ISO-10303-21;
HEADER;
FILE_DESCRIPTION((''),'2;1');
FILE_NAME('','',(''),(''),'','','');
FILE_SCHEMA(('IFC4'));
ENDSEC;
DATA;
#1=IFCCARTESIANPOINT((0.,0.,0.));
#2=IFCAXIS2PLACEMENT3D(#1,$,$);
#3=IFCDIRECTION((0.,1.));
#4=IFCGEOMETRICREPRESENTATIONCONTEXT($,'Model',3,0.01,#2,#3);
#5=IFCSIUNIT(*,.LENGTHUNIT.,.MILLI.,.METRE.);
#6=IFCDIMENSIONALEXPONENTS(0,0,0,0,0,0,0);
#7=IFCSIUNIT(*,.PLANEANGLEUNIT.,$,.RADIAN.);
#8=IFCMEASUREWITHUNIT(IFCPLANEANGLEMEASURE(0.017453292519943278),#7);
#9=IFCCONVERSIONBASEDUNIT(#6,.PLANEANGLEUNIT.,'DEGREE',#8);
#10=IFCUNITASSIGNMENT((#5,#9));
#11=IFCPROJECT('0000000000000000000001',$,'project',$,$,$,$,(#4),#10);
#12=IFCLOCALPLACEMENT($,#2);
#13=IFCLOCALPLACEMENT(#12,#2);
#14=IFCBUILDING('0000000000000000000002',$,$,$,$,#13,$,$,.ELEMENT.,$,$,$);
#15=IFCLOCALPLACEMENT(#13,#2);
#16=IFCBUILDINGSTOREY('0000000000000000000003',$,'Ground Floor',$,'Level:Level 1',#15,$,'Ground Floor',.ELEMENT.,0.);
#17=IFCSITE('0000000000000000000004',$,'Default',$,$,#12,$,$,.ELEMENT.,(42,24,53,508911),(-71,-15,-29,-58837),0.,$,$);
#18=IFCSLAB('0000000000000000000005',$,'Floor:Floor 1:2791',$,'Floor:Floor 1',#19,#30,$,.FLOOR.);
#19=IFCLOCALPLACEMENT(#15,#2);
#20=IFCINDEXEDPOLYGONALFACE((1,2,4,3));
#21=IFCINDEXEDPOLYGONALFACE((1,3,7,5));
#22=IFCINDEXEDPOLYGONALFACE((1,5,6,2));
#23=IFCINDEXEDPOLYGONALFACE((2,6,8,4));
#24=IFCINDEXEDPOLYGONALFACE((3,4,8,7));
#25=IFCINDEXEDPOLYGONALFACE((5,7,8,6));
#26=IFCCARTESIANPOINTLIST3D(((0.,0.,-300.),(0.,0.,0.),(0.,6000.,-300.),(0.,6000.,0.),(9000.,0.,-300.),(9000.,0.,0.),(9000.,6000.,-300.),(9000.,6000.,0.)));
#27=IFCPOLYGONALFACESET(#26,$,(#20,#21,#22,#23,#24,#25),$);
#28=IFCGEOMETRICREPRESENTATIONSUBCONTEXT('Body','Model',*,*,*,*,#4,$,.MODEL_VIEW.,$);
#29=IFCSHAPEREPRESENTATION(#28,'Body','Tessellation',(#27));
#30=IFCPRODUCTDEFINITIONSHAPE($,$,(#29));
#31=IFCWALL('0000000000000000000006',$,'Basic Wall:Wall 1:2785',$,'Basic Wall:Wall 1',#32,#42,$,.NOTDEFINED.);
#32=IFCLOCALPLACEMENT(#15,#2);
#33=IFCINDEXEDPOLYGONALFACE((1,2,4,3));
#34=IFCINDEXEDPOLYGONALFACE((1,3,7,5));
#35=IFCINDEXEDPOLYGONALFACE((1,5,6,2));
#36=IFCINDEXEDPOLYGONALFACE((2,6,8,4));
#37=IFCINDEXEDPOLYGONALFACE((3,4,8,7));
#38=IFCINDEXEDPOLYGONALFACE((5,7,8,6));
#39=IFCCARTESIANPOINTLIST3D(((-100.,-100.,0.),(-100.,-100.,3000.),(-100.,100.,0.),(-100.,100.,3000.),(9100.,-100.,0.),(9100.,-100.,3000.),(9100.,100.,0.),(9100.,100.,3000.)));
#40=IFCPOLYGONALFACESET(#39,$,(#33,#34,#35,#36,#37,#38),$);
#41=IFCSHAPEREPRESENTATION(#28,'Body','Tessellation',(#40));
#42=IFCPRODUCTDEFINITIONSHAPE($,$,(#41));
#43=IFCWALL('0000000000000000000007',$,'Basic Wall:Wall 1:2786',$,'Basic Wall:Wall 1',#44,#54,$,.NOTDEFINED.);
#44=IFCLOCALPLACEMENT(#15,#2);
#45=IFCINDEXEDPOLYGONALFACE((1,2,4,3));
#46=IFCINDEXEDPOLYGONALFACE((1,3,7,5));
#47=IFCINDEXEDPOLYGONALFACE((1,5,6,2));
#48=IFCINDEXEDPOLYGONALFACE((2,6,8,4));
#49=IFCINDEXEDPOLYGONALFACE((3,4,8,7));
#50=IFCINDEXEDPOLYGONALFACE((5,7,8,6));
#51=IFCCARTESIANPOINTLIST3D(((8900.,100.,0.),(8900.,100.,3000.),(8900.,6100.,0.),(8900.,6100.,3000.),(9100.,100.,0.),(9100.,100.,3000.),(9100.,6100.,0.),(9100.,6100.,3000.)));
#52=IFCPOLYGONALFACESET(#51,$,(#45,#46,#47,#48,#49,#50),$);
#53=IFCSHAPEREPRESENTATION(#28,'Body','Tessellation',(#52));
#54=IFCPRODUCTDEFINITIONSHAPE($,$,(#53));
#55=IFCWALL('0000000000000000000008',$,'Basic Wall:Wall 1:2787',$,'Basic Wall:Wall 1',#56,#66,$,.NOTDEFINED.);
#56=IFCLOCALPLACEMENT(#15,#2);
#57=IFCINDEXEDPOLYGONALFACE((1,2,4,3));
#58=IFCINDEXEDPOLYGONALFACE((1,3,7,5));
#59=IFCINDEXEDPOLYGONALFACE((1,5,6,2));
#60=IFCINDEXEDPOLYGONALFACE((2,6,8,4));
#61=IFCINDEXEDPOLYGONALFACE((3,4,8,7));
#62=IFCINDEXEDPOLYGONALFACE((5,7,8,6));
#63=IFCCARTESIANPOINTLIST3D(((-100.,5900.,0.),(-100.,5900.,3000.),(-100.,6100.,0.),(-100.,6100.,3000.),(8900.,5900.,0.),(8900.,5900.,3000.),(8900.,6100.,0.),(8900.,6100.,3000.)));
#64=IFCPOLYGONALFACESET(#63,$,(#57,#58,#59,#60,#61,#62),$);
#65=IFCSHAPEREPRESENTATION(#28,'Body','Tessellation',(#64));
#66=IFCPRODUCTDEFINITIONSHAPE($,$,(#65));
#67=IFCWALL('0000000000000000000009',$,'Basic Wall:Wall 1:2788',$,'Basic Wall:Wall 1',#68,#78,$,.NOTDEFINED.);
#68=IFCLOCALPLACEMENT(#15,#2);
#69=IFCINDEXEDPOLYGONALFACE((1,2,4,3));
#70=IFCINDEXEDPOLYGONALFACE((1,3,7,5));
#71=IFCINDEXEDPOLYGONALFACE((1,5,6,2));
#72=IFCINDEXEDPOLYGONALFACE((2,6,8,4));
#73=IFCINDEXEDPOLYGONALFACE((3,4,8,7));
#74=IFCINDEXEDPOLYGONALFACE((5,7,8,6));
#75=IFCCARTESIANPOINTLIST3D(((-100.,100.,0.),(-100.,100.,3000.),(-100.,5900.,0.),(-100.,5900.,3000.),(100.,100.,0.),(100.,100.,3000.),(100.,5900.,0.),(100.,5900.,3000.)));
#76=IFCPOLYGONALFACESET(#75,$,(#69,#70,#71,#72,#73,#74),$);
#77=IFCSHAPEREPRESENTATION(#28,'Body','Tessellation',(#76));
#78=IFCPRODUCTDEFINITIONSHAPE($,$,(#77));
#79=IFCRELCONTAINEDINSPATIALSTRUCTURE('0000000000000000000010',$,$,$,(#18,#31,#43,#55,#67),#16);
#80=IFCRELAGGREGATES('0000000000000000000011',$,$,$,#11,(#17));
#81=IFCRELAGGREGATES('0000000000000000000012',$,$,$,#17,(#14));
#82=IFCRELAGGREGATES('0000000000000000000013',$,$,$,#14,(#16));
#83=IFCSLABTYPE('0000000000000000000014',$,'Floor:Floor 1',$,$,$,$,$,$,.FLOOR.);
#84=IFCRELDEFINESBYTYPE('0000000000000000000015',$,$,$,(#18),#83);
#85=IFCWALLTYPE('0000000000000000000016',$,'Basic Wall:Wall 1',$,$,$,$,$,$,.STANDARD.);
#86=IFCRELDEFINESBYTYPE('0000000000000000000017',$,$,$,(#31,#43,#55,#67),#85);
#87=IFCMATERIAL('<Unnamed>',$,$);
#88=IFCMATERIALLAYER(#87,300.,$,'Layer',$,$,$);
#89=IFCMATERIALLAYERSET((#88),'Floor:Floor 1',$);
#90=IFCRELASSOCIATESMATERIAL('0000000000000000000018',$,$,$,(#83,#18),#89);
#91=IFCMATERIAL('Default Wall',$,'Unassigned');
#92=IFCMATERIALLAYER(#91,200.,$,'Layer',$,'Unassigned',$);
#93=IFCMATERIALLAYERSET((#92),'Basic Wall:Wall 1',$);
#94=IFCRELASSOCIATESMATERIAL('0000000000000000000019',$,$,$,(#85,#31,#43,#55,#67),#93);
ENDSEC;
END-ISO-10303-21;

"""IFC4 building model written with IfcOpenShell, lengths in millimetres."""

from ifc_helpers import new_model, entity, si_unit, converted_unit, direction, frame, frame_2d, origin, origin_2d_with_axis, place, context, subcontext, project, spatial, rectangle, extrude, material, layer, layer_set, layer_usage, type_object, element, save


model = new_model("IFC4")

# Units and contexts
model_context = context("Model", 3, precision=0.01, world=origin(), true_north=direction((0.0, 1.0)))
body_context = subcontext(model_context, "Body", "Model", "MODEL_VIEW")
ifc_project = project(units=[si_unit("LENGTHUNIT", "METRE", prefix="MILLI"), converted_unit("PLANEANGLEUNIT", "DEGREE", entity("IfcPlaneAngleMeasure", 0.017453292519943278), si_unit("PLANEANGLEUNIT", "RADIAN"), dimensions=[0, 0, 0, 0, 0, 0, 0])], contexts=[model_context])

# Site, building, storey
site_placement = place(None, origin())
site = spatial("IfcSite", under=ifc_project, at=site_placement, Name="Default", CompositionType="ELEMENT", RefLatitude=(42, 24, 53, 508911), RefLongitude=(-71, -15, -29, -58837), RefElevation=0.0)
building_placement = place(site_placement, origin())
building = spatial("IfcBuilding", under=site, at=building_placement, CompositionType="ELEMENT")
storey_placement = place(building_placement, origin())
storey = spatial("IfcBuildingStorey", under=building, at=storey_placement, Name="Ground Floor", ObjectType="Level:Level 1", LongName="Ground Floor", CompositionType="ELEMENT", Elevation=0.0)

# Slab
ifc_material_1 = material(Name="<Unnamed>")
ifc_layer_1 = layer(ifc_material_1, 300.0, Name="Layer")
ifc_layer_set_1 = layer_set([ifc_layer_1], Name="Floor:Floor 1")
ifc_layer_usage_1 = layer_usage(ifc_layer_set_1, "AXIS3", "POSITIVE", 0.0)
slab_type = type_object("IfcSlabType", Name="Floor:Floor 1", PredefinedType="FLOOR", material=ifc_layer_set_1)
slab_placement = place(storey_placement, origin())
element("IfcSlab", 1, at=slab_placement, inside=storey, type_object=slab_type, material=ifc_layer_usage_1, Name="Floor:Floor 1:2791", ObjectType="Floor:Floor 1", PredefinedType="FLOOR", context=body_context, shape_type="SweptSolid", body=[
    extrude(rectangle(XDim=6000.0, YDim=9000.0, at=origin_2d_with_axis()), frame((4500.0, 3000.0, 0.0), z_axis=(0.0, 0.0, -1.0), x_axis=(0.0, 1.0, 0.0)), (0.0, 0.0, 1.0), 300.0),
])

# Walls
ifc_material_2 = material(Name="Default Wall", Category="Unassigned")
ifc_layer_2 = layer(ifc_material_2, 200.0, Name="Layer", Category="Unassigned")
ifc_layer_set_2 = layer_set([ifc_layer_2], Name="Basic Wall:Wall 1")
ifc_layer_usage_2 = layer_usage(ifc_layer_set_2, "AXIS2", "NEGATIVE", 100.0)
wall_type = type_object("IfcWallType", Name="Basic Wall:Wall 1", PredefinedType="STANDARD", material=ifc_layer_set_2)
wall_1_placement = place(storey_placement, frame((-100.0, 0.0, 0.0)))
element("IfcWall", 2, at=wall_1_placement, inside=storey, type_object=wall_type, material=ifc_layer_usage_2, Name="Basic Wall:Wall 1:2785", ObjectType="Basic Wall:Wall 1", PredefinedType="NOTDEFINED", context=body_context, shape_type="SweptSolid", body=[
    extrude(rectangle(XDim=9200.0, YDim=200.0, at=frame_2d((4600.0, 0.0), x_axis=(-1.0, 0.0))), origin(), (0.0, 0.0, 1.0), 3000.0),
])
ifc_layer_usage_3 = layer_usage(ifc_layer_set_2, "AXIS2", "NEGATIVE", 100.0)
wall_2_placement = place(storey_placement, frame((9000.0, 100.0, 0.0), z_axis=(0.0, 0.0, 1.0), x_axis=(0.0, 1.0, 0.0)))
element("IfcWall", 3, at=wall_2_placement, inside=storey, type_object=wall_type, material=ifc_layer_usage_3, Name="Basic Wall:Wall 1:2786", ObjectType="Basic Wall:Wall 1", PredefinedType="NOTDEFINED", context=body_context, shape_type="SweptSolid", body=[
    extrude(rectangle(XDim=6000.0, YDim=200.0, at=frame_2d((3000.0, 0.0), x_axis=(-1.0, 0.0))), origin(), (0.0, 0.0, 1.0), 3000.0),
])
ifc_layer_usage_4 = layer_usage(ifc_layer_set_2, "AXIS2", "NEGATIVE", 100.0)
wall_3_placement = place(storey_placement, frame((8900.0, 6000.0, 0.0), z_axis=(0.0, 0.0, 1.0), x_axis=(-1.0, 0.0, 0.0)))
element("IfcWall", 4, at=wall_3_placement, inside=storey, type_object=wall_type, material=ifc_layer_usage_4, Name="Basic Wall:Wall 1:2787", ObjectType="Basic Wall:Wall 1", PredefinedType="NOTDEFINED", context=body_context, shape_type="SweptSolid", body=[
    extrude(rectangle(XDim=9000.0, YDim=200.0, at=frame_2d((4500.0, 0.0), x_axis=(-1.0, 0.0))), origin(), (0.0, 0.0, 1.0), 3000.0),
])
ifc_layer_usage_5 = layer_usage(ifc_layer_set_2, "AXIS2", "NEGATIVE", 100.0)
wall_4_placement = place(storey_placement, frame((0.0, 5900.0, 0.0), z_axis=(0.0, 0.0, 1.0), x_axis=(0.0, -1.0, 0.0)))
element("IfcWall", 5, at=wall_4_placement, inside=storey, type_object=wall_type, material=ifc_layer_usage_5, Name="Basic Wall:Wall 1:2788", ObjectType="Basic Wall:Wall 1", PredefinedType="NOTDEFINED", context=body_context, shape_type="SweptSolid", body=[
    extrude(rectangle(XDim=5800.0, YDim=200.0, at=frame_2d((2900.0, 0.0), x_axis=(-1.0, 0.0))), origin(), (0.0, 0.0, 1.0), 3000.0),
])

save(model, "model.ifc")
